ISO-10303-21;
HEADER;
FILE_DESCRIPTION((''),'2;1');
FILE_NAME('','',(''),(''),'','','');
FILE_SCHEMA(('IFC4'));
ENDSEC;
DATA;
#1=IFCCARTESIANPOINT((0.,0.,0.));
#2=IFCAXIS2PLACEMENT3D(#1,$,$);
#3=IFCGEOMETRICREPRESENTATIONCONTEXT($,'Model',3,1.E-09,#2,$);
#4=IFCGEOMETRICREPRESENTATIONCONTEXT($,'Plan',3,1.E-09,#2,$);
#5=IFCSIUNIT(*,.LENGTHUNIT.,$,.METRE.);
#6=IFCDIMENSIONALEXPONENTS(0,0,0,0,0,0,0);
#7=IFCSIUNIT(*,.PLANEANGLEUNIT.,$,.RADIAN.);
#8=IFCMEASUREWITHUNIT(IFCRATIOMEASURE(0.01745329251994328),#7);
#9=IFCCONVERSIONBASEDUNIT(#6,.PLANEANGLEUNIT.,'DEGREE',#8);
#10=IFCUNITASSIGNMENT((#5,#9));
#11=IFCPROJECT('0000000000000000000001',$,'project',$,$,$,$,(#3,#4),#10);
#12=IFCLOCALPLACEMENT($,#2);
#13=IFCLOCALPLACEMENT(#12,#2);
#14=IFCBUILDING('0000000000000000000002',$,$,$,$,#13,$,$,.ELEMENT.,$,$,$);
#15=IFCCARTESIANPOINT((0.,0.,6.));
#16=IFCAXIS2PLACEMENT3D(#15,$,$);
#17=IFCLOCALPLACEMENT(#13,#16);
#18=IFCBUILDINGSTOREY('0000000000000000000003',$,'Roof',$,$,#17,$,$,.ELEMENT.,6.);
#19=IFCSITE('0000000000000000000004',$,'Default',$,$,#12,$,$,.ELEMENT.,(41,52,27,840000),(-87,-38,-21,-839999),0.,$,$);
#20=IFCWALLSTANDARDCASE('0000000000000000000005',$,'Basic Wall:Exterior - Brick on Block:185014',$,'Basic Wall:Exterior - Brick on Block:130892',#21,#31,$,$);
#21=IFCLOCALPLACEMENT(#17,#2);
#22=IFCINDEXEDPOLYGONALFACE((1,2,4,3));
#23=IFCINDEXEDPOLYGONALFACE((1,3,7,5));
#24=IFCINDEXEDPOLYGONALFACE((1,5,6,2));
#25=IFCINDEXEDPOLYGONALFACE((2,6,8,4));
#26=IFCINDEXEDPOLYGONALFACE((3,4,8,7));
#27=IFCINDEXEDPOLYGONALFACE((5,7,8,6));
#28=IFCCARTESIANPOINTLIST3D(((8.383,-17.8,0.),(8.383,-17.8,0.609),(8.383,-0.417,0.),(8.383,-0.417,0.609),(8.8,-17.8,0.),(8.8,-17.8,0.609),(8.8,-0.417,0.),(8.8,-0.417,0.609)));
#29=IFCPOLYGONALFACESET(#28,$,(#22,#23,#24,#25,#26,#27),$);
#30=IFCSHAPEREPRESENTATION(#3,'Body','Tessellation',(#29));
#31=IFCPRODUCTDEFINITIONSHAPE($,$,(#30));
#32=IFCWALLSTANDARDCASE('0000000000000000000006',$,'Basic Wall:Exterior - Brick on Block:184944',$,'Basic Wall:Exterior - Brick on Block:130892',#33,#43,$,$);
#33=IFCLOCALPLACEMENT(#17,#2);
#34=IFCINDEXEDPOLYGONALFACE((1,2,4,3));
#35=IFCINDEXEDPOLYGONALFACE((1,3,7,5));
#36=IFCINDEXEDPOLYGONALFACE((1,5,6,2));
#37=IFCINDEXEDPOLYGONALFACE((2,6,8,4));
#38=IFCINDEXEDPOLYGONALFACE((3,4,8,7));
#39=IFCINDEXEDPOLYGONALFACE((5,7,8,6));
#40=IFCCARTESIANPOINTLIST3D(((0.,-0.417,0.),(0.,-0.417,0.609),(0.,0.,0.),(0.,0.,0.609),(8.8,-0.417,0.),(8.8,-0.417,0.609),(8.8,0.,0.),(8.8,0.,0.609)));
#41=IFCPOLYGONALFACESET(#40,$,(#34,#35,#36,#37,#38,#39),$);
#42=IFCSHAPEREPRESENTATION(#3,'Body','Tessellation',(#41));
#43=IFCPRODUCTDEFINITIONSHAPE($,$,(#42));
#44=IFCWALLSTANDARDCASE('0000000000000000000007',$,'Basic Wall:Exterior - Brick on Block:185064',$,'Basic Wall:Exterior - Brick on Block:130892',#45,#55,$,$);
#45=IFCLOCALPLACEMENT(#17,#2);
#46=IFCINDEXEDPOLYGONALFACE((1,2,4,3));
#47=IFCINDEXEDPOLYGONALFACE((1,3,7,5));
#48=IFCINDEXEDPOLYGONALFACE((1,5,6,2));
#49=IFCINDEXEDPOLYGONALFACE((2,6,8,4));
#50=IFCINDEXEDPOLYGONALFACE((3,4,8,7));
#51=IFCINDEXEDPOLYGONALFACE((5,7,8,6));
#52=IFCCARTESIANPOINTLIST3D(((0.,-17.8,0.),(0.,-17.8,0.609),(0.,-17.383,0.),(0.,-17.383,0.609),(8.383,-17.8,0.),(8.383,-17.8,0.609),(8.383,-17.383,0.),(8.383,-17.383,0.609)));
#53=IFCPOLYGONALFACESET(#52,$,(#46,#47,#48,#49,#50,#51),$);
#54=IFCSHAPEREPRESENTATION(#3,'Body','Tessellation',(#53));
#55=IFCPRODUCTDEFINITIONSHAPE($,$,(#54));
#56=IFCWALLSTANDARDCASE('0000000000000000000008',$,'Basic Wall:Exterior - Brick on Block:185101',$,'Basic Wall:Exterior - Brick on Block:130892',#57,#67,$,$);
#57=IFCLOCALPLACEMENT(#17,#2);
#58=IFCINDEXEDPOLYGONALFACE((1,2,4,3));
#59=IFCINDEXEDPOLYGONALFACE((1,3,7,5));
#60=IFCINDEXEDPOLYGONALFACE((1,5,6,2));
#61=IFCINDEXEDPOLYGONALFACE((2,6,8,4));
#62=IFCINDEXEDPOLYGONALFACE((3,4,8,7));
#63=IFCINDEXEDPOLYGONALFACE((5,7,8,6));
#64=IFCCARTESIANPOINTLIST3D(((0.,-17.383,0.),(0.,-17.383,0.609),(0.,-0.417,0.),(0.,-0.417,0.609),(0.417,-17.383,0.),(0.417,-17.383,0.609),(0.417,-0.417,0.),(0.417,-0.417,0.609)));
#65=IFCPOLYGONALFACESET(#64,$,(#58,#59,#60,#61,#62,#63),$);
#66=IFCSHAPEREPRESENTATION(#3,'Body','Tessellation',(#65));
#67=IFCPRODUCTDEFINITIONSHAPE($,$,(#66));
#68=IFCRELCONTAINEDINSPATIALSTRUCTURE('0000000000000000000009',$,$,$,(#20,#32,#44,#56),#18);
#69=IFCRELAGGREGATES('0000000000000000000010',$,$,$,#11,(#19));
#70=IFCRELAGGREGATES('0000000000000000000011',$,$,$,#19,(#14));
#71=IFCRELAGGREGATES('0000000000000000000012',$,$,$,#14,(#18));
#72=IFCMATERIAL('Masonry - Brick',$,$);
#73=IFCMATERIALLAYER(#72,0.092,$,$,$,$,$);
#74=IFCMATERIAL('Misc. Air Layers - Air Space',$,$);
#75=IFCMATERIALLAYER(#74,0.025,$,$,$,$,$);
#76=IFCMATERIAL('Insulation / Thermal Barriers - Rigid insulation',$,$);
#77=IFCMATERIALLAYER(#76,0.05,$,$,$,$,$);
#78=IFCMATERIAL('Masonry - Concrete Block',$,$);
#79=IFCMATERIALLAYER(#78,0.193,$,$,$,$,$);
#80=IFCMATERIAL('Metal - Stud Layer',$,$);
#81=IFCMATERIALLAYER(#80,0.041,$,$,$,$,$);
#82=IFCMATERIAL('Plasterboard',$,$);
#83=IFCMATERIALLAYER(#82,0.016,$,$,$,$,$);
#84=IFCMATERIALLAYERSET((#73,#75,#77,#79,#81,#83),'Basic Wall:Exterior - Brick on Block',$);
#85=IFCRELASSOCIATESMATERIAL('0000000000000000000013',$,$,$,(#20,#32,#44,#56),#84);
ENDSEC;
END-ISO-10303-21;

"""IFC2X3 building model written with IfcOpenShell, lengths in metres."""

from ifc_helpers import new_model, entity, si_unit, converted_unit, frame, frame_2d, origin, place, context, project, spatial, rectangle, extrude, material, layer, layer_set, layer_usage, element, save


model = new_model("IFC2X3")

# Units and contexts
model_context = context("Model", 3, precision=1e-09, world=origin())
plan_context = context("Plan", 3, precision=1e-09, world=origin())
ifc_project = project(units=[si_unit("LENGTHUNIT", "METRE"), converted_unit("PLANEANGLEUNIT", "DEGREE", entity("IfcRatioMeasure", 0.01745329251994328), si_unit("PLANEANGLEUNIT", "RADIAN"), dimensions=[0, 0, 0, 0, 0, 0, 0])], contexts=[model_context, plan_context])

# Site, building, storey
site_placement = place(None, origin())
site = spatial("IfcSite", under=ifc_project, at=site_placement, Name="Default", CompositionType="ELEMENT", RefLatitude=(41, 52, 27, 840000), RefLongitude=(-87, -38, -21, -839999), RefElevation=0.0)
building_placement = place(site_placement, origin())
building = spatial("IfcBuilding", under=site, at=building_placement, CompositionType="ELEMENT")
storey_placement = place(building_placement, frame((0.0, 0.0, 6.0)))
storey = spatial("IfcBuildingStorey", under=building, at=storey_placement, Name="Roof", CompositionType="ELEMENT", Elevation=6.0)

# Walls
ifc_material_1 = material(Name="Masonry - Brick")
ifc_layer_1 = layer(ifc_material_1, 0.092)
ifc_material_2 = material(Name="Misc. Air Layers - Air Space")
ifc_layer_2 = layer(ifc_material_2, 0.025)
ifc_material_3 = material(Name="Insulation / Thermal Barriers - Rigid insulation")
ifc_layer_3 = layer(ifc_material_3, 0.05)
ifc_material_4 = material(Name="Masonry - Concrete Block")
ifc_layer_4 = layer(ifc_material_4, 0.193)
ifc_material_5 = material(Name="Metal - Stud Layer")
ifc_layer_5 = layer(ifc_material_5, 0.041)
ifc_material_6 = material(Name="Plasterboard")
ifc_layer_6 = layer(ifc_material_6, 0.016)
ifc_layer_set = layer_set([ifc_layer_1, ifc_layer_2, ifc_layer_3, ifc_layer_4, ifc_layer_5, ifc_layer_6], Name="Basic Wall:Exterior - Brick on Block")
ifc_layer_usage = layer_usage(ifc_layer_set, "AXIS2", "NEGATIVE", 0.2085)
wall_1_placement = place(storey_placement, frame((8.5915, -0.417, 0.0), z_axis=(0.0, 0.0, 1.0), x_axis=(0.0, -1.0, 0.0)))
element("IfcWallStandardCase", 1, at=wall_1_placement, inside=storey, material=ifc_layer_usage, Name="Basic Wall:Exterior - Brick on Block:185014", ObjectType="Basic Wall:Exterior - Brick on Block:130892", context=model_context, shape_type="SweptSolid", body=[
    extrude(rectangle(XDim=17.383, YDim=0.417, at=frame_2d((8.6915, 0.0), x_axis=(-1.0, 0.0))), origin(), (0.0, 0.0, 1.0), 0.609),
])
wall_2_placement = place(storey_placement, frame((0.0, -0.2085, 0.0)))
element("IfcWallStandardCase", 2, at=wall_2_placement, inside=storey, material=ifc_layer_usage, Name="Basic Wall:Exterior - Brick on Block:184944", ObjectType="Basic Wall:Exterior - Brick on Block:130892", context=model_context, shape_type="SweptSolid", body=[
    extrude(rectangle(XDim=8.8, YDim=0.417, at=frame_2d((4.4, 0.0), x_axis=(-1.0, 0.0))), origin(), (0.0, 0.0, 1.0), 0.609),
])
wall_3_placement = place(storey_placement, frame((8.383, -17.5915, 0.0), z_axis=(0.0, 0.0, 1.0), x_axis=(-1.0, 0.0, 0.0)))
element("IfcWallStandardCase", 3, at=wall_3_placement, inside=storey, material=ifc_layer_usage, Name="Basic Wall:Exterior - Brick on Block:185064", ObjectType="Basic Wall:Exterior - Brick on Block:130892", context=model_context, shape_type="SweptSolid", body=[
    extrude(rectangle(XDim=8.383, YDim=0.417, at=frame_2d((4.1915, 0.0), x_axis=(-1.0, 0.0))), origin(), (0.0, 0.0, 1.0), 0.609),
])
wall_4_placement = place(storey_placement, frame((0.2085, -17.383, 0.0), z_axis=(0.0, 0.0, 1.0), x_axis=(0.0, 1.0, 0.0)))
element("IfcWallStandardCase", 4, at=wall_4_placement, inside=storey, material=ifc_layer_usage, Name="Basic Wall:Exterior - Brick on Block:185101", ObjectType="Basic Wall:Exterior - Brick on Block:130892", context=model_context, shape_type="SweptSolid", body=[
    extrude(rectangle(XDim=16.966, YDim=0.417, at=frame_2d((8.483, 0.0), x_axis=(-1.0, 0.0))), origin(), (0.0, 0.0, 1.0), 0.609),
])

save(model, "model.ifc")
